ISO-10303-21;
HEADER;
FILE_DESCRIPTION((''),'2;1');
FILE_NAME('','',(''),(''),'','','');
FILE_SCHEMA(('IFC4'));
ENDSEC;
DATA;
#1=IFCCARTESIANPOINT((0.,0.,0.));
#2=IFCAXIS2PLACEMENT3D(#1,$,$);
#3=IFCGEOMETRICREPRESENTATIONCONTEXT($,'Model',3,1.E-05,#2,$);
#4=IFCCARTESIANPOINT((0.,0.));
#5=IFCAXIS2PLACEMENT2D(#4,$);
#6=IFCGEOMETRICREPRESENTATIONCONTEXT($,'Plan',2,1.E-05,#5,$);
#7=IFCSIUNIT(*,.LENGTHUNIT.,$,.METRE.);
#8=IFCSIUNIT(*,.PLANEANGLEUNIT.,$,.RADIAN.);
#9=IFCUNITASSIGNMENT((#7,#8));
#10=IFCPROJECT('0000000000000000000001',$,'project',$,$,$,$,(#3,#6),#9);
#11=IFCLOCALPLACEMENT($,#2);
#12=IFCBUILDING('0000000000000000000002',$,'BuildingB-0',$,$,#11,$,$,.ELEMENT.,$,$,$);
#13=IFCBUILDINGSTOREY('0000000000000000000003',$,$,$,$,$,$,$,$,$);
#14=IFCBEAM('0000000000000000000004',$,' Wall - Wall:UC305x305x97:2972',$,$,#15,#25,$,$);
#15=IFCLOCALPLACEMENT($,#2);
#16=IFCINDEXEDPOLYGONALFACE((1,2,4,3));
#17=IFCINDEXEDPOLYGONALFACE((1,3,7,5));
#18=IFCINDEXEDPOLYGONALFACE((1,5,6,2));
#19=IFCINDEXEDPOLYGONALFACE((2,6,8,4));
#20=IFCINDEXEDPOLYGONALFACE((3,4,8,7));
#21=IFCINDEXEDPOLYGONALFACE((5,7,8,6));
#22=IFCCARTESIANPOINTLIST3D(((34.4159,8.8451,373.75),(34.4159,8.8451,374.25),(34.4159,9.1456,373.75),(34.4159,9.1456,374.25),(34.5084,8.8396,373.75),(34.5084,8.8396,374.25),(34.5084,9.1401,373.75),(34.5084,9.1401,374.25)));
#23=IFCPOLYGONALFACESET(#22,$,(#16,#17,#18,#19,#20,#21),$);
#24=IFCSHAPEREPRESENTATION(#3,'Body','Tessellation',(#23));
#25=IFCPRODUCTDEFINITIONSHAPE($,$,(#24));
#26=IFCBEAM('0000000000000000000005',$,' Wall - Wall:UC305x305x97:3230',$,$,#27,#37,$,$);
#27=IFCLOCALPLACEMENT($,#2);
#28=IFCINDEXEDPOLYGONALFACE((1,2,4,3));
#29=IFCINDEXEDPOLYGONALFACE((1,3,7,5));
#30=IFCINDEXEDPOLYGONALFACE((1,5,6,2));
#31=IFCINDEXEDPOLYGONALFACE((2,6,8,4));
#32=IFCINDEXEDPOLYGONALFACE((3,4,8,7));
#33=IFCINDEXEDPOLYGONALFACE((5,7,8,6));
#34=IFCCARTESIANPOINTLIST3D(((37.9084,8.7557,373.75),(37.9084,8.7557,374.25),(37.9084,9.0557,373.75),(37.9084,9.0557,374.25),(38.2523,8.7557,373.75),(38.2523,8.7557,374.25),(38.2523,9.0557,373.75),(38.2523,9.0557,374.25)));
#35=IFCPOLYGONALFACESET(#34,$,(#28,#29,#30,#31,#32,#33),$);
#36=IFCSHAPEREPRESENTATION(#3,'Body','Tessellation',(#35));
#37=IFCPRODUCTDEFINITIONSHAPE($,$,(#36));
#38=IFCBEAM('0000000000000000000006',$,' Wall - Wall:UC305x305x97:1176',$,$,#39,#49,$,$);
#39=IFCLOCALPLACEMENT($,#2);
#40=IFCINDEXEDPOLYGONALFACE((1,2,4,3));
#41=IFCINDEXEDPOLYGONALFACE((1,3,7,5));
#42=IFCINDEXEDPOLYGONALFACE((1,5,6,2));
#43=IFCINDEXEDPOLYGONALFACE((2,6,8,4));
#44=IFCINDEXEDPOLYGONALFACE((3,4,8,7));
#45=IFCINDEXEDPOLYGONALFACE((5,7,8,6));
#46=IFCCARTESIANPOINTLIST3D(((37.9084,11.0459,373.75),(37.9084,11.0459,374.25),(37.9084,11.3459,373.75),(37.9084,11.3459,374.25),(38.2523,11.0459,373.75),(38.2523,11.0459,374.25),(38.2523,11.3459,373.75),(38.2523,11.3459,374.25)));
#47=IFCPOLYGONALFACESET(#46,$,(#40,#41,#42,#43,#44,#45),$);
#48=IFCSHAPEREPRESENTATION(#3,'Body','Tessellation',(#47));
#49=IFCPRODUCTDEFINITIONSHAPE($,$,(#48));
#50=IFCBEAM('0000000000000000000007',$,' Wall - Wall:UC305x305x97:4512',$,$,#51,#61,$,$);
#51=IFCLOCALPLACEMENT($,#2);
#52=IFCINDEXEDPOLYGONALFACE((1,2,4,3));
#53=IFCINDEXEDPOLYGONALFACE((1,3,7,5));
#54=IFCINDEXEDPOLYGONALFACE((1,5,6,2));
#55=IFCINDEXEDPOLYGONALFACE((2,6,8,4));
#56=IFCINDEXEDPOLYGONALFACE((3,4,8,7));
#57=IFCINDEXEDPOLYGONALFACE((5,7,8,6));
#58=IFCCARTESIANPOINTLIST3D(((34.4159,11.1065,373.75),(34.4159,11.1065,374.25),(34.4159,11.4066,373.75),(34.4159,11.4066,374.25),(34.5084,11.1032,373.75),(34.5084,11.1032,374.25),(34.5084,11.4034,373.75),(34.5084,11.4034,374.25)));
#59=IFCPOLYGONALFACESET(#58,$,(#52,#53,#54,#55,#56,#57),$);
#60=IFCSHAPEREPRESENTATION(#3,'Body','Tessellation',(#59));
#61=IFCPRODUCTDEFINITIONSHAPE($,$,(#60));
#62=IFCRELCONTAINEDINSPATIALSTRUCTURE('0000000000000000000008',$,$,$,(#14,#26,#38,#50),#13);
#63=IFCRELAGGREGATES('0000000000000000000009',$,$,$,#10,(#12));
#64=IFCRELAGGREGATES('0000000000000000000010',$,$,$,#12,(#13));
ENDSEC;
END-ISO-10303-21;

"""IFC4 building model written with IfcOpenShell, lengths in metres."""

from ifc_helpers import new_model, si_unit, origin, origin_2d, place, context, project, spatial, polyline, outline, extrude, element, save


model = new_model("IFC4")

# Units and contexts
model_context = context("Model", 3, precision=1e-05, world=origin())
plan_context = context("Plan", 2, precision=1e-05, world=origin_2d())
ifc_project = project(units=[si_unit("LENGTHUNIT", "METRE"), si_unit("PLANEANGLEUNIT", "RADIAN")], contexts=[model_context, plan_context])

# Building, storey
building_placement = place(None, origin())
building = spatial("IfcBuilding", under=ifc_project, at=building_placement, Name="BuildingB-0", CompositionType="ELEMENT")
storey = spatial("IfcBuildingStorey", under=building)

# Beams
element("IfcBeam", 1, inside=storey, Name=" Wall - Wall:UC305x305x97:2972", context=model_context, shape_type="SweptSolid", body=[
    extrude(outline(polyline([(34.4159, 8.8451, 373.75), (34.5084, 8.8396, 373.75), (34.5084, 9.1401, 373.75), (34.4159, 9.1456, 373.75), (34.4159, 8.8451, 373.75)])), None, (0.0, 0.0, 1.0), 0.5),
])
element("IfcBeam", 2, inside=storey, Name=" Wall - Wall:UC305x305x97:3230", context=model_context, shape_type="SweptSolid", body=[
    extrude(outline(polyline([(37.9084, 8.7557, 373.75), (38.2523, 8.7557, 373.75), (38.2523, 9.0557, 373.75), (37.9084, 9.0557, 373.75), (37.9084, 8.7557, 373.75)])), None, (0.0, 0.0, 1.0), 0.5),
])
element("IfcBeam", 3, inside=storey, Name=" Wall - Wall:UC305x305x97:1176", context=model_context, shape_type="SweptSolid", body=[
    extrude(outline(polyline([(37.9084, 11.0459, 373.75), (38.2523, 11.0459, 373.75), (38.2523, 11.3459, 373.75), (37.9084, 11.3459, 373.75), (37.9084, 11.0459, 373.75)])), None, (0.0, 0.0, 1.0), 0.5),
])
element("IfcBeam", 4, inside=storey, Name=" Wall - Wall:UC305x305x97:4512", context=model_context, shape_type="SweptSolid", body=[
    extrude(outline(polyline([(34.4159, 11.1065, 373.75), (34.5084, 11.1032, 373.75), (34.5084, 11.4034, 373.75), (34.4159, 11.4066, 373.75), (34.4159, 11.1065, 373.75)])), None, (0.0, 0.0, 1.0), 0.5),
])

save(model, "model.ifc")
